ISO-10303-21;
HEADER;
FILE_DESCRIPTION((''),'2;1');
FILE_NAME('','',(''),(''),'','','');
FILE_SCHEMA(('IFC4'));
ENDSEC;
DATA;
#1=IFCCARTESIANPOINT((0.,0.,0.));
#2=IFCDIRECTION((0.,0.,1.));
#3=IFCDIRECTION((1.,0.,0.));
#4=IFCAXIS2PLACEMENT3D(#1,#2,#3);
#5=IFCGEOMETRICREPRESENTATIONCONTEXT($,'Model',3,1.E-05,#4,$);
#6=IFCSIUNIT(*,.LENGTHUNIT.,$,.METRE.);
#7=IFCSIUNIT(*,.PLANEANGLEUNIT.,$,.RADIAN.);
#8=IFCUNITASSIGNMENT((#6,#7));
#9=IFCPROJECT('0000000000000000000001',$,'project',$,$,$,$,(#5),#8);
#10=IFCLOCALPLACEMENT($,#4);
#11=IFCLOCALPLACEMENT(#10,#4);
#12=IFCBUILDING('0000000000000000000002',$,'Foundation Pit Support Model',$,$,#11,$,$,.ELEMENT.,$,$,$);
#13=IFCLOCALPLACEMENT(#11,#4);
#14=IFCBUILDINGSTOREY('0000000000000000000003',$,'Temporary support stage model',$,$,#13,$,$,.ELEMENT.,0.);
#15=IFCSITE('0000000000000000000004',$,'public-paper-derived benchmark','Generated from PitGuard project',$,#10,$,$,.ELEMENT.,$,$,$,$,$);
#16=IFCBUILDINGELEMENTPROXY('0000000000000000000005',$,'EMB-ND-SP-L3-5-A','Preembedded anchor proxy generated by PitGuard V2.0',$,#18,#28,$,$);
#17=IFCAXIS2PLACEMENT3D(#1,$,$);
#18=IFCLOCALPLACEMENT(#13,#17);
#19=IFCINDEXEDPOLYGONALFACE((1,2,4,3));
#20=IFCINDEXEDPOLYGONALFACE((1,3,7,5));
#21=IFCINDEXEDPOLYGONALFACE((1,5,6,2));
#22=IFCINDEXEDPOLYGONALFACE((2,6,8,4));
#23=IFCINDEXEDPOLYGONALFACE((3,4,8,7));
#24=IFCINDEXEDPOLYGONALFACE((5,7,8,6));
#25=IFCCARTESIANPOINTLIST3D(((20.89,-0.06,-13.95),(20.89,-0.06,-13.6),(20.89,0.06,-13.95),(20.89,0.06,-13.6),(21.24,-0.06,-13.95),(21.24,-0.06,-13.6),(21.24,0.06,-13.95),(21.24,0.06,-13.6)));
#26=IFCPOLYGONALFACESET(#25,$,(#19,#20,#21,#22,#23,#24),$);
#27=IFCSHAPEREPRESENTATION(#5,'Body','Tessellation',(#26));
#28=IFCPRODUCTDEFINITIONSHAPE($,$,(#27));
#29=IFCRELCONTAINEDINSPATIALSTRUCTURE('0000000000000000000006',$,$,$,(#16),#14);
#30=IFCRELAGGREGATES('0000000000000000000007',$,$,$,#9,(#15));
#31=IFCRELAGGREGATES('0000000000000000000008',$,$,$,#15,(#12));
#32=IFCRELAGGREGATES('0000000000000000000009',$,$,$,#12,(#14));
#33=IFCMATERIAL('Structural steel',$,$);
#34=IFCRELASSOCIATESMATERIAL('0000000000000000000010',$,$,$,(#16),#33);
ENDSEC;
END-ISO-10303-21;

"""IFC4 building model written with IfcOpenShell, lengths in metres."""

from ifc_helpers import new_model, si_unit, frame, origin_with_axes, origin_2d, place, context, project, spatial, rectangle, extrude, material, element, save


model = new_model("IFC4")

# Units and contexts
model_context = context("Model", 3, precision=1e-05, world=origin_with_axes())
ifc_project = project(units=[si_unit("LENGTHUNIT", "METRE"), si_unit("PLANEANGLEUNIT", "RADIAN")], contexts=[model_context])

# Site, building, storey
site_placement = place(None, origin_with_axes())
site = spatial("IfcSite", under=ifc_project, at=site_placement, Name="public-paper-derived benchmark", Description="Generated from PitGuard project", CompositionType="ELEMENT")
building_placement = place(site_placement, origin_with_axes())
building = spatial("IfcBuilding", under=site, at=building_placement, Name="Foundation Pit Support Model", CompositionType="ELEMENT")
storey_placement = place(building_placement, origin_with_axes())
storey = spatial("IfcBuildingStorey", under=building, at=storey_placement, Name="Temporary support stage model", CompositionType="ELEMENT", Elevation=0.0)

# Shared definitions
ifc_material_1 = material(Name="Structural steel")

# Building element proxy
proxy_1_placement = place(storey_placement, frame((21.065, 0.0, -13.95), z_axis=(0.0, 0.0, 1.0), x_axis=(1.0, 0.0, 0.0)))
element("IfcBuildingElementProxy", 1, at=proxy_1_placement, inside=storey, material=ifc_material_1, Name="EMB-ND-SP-L3-5-A", Description="Preembedded anchor proxy generated by PitGuard V2.0", context=model_context, shape_type="SweptSolid", body=[
    extrude(rectangle(XDim=0.35, YDim=0.12, at=origin_2d()), origin_with_axes(), (0.0, 0.0, 1.0), 0.35),
])

save(model, "model.ifc")
